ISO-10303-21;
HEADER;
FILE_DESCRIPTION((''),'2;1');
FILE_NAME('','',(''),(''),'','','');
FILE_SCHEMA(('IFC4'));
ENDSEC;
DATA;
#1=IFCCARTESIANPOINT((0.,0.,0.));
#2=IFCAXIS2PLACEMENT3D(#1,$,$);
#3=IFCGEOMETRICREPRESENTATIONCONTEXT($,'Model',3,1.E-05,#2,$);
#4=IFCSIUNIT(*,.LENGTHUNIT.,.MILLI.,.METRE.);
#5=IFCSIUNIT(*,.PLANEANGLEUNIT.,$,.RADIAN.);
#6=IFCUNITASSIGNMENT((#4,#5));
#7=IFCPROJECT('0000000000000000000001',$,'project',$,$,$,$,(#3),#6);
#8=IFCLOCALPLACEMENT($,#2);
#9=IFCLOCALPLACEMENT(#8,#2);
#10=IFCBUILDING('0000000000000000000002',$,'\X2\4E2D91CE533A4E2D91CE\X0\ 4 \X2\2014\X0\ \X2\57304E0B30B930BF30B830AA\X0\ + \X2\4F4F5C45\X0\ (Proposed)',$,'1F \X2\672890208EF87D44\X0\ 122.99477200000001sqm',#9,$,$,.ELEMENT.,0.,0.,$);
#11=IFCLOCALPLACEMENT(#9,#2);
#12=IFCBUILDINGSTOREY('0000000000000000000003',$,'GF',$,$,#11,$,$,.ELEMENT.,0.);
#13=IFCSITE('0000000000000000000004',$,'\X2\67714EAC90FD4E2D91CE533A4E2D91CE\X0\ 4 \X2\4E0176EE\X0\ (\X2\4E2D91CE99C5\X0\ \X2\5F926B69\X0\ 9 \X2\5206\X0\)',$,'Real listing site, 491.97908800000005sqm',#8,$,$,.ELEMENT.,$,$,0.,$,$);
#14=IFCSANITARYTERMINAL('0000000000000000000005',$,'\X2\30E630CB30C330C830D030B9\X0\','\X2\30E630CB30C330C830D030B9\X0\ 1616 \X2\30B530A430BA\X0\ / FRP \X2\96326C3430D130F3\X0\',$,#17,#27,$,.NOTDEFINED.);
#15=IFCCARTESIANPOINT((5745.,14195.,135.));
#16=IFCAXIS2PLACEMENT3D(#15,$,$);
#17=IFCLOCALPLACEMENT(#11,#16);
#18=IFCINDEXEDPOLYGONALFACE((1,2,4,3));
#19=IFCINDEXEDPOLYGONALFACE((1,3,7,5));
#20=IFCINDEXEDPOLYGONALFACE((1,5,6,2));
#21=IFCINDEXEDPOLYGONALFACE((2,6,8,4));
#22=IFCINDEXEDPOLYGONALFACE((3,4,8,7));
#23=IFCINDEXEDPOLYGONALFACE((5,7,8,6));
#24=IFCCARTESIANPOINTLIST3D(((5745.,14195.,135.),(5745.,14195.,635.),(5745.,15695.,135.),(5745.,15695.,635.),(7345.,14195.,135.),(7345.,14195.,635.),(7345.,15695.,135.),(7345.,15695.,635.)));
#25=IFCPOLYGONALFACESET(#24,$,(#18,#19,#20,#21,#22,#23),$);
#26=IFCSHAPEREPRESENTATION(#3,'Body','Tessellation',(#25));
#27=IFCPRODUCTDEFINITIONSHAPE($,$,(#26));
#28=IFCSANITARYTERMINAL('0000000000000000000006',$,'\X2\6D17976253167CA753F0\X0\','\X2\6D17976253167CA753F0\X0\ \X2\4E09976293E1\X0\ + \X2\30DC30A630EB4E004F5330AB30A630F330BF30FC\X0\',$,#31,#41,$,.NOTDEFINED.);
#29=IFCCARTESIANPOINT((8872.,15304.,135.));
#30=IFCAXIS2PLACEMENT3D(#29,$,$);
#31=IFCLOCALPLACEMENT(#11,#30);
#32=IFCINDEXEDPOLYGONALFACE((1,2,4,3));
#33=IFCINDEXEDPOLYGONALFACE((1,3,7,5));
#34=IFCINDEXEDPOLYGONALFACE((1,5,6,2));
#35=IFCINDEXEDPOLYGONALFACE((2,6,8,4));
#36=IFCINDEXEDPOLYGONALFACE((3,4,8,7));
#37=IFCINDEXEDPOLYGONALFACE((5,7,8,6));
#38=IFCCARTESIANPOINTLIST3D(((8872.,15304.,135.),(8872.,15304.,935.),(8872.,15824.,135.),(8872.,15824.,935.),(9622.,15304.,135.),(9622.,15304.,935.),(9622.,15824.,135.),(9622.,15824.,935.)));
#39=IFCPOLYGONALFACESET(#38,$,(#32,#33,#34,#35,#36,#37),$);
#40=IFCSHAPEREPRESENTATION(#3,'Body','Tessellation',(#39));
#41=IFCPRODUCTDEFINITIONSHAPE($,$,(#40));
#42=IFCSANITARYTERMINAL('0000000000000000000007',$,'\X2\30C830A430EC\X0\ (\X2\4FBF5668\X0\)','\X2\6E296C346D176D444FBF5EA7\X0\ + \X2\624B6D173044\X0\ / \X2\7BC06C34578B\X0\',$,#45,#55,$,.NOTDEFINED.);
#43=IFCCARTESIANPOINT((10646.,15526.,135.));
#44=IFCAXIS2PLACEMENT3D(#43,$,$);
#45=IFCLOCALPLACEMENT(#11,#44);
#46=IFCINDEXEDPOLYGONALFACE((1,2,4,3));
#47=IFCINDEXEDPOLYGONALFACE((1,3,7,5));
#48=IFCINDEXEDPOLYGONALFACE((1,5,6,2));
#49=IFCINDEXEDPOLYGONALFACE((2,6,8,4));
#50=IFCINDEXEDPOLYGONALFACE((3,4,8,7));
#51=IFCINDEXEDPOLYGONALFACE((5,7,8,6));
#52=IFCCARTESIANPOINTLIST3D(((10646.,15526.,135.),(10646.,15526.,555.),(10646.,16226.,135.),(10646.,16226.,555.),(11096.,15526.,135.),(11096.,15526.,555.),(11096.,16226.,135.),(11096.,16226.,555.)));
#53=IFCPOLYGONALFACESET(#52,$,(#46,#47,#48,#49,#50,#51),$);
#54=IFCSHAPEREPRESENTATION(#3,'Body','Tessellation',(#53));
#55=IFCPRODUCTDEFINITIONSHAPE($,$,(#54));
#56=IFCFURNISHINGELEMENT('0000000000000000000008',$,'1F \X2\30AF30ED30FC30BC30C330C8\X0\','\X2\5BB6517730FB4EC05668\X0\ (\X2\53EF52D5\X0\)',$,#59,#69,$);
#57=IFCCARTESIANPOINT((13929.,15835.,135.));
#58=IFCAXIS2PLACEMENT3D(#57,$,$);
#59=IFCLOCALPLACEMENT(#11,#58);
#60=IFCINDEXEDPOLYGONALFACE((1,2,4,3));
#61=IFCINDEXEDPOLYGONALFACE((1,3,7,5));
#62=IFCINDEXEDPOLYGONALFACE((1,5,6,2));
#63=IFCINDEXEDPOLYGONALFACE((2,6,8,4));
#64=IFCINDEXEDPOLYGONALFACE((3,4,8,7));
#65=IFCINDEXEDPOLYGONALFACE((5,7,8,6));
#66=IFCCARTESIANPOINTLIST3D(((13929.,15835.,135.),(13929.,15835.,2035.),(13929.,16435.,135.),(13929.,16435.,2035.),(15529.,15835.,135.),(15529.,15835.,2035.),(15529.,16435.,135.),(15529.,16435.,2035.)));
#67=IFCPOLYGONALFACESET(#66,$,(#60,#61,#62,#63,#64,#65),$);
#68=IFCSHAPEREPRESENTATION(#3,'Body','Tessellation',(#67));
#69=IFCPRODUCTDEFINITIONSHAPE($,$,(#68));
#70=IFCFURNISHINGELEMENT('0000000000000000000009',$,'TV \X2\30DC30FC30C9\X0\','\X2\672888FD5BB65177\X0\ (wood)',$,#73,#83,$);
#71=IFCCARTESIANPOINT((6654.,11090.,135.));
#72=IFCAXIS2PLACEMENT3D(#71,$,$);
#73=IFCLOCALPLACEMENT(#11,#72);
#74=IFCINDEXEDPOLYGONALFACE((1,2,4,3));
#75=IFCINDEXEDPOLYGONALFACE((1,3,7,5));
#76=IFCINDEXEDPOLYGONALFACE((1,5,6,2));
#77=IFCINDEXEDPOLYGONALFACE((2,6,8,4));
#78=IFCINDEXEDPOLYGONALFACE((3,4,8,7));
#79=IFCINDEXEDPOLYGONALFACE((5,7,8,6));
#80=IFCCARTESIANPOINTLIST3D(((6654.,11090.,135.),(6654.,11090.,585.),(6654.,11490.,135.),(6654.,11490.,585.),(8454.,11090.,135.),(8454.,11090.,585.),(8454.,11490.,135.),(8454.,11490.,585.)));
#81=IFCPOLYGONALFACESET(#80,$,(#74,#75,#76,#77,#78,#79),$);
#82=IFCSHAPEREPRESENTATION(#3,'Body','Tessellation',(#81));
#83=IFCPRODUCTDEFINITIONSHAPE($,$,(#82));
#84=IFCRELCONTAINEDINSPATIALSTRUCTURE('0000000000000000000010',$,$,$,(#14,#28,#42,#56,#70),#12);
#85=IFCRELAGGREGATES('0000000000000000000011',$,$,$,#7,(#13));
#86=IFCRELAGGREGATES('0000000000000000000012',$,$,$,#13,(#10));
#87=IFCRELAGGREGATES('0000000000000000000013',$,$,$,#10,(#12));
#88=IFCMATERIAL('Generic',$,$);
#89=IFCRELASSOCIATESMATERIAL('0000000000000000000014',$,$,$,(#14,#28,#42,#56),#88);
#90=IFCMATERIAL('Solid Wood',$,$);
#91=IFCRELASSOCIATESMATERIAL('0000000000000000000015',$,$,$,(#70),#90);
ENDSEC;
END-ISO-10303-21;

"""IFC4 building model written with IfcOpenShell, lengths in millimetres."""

from ifc_helpers import new_model, si_unit, frame, frame_2d, origin, place, context, project, spatial, rectangle, extrude, material, element, save


model = new_model("IFC4")

# Units and contexts
model_context = context("Model", 3, precision=1e-05, world=origin())
ifc_project = project(units=[si_unit("LENGTHUNIT", "METRE", prefix="MILLI"), si_unit("PLANEANGLEUNIT", "RADIAN")], contexts=[model_context])

# Site, building, storey
site_placement = place(None, origin())
site = spatial("IfcSite", under=ifc_project, at=site_placement, Name="東京都中野区中野 4 丁目 (中野駅 徒歩 9 分)", ObjectType="Real listing site, 491.97908800000005sqm", CompositionType="ELEMENT", RefElevation=0.0)
building_placement = place(site_placement, origin())
building = spatial("IfcBuilding", under=site, at=building_placement, Name="中野区中野 4 — 地下スタジオ + 住居 (Proposed)", ObjectType="1F 木造軸組 122.99477200000001sqm", CompositionType="ELEMENT", ElevationOfRefHeight=0.0, ElevationOfTerrain=0.0)
storey_placement = place(building_placement, origin())
storey = spatial("IfcBuildingStorey", under=building, at=storey_placement, Name="GF", CompositionType="ELEMENT", Elevation=0.0)

# Shared definitions
ifc_material_1 = material(Name="Solid Wood")

# Sanitary terminals
ifc_material_2 = material(Name="Generic")
sanitary_terminal_1_placement = place(storey_placement, frame((5745.0, 14195.0, 135.0)))
element("IfcSanitaryTerminal", 1, at=sanitary_terminal_1_placement, inside=storey, material=ifc_material_2, Name="ユニットバス", Description="ユニットバス 1616 サイズ / FRP 防水パン", PredefinedType="NOTDEFINED", context=model_context, shape_type="SweptSolid", body=[
    extrude(rectangle(XDim=1600.0, YDim=1500.0, at=frame_2d((800.0, 750.0))), frame((5745.0, 14195.0, 135.0)), (0.0, 0.0, 1.0), 500.0),
])
sanitary_terminal_2_placement = place(storey_placement, frame((8872.0, 15304.0, 135.0)))
element("IfcSanitaryTerminal", 2, at=sanitary_terminal_2_placement, inside=storey, material=ifc_material_2, Name="洗面化粧台", Description="洗面化粧台 三面鏡 + ボウル一体カウンター", PredefinedType="NOTDEFINED", context=model_context, shape_type="SweptSolid", body=[
    extrude(rectangle(XDim=750.0, YDim=520.0, at=frame_2d((375.0, 260.0))), frame((8872.0, 15304.0, 135.0)), (0.0, 0.0, 1.0), 800.0),
])
sanitary_terminal_3_placement = place(storey_placement, frame((10646.0, 15526.0, 135.0)))
element("IfcSanitaryTerminal", 3, at=sanitary_terminal_3_placement, inside=storey, material=ifc_material_2, Name="トイレ (便器)", Description="温水洗浄便座 + 手洗い / 節水型", PredefinedType="NOTDEFINED", context=model_context, shape_type="SweptSolid", body=[
    extrude(rectangle(XDim=450.0, YDim=700.0, at=frame_2d((225.0, 350.0))), frame((10646.0, 15526.0, 135.0)), (0.0, 0.0, 1.0), 420.0),
])

# Furnishing elements
furnishing_1_placement = place(storey_placement, frame((13929.0, 15835.0, 135.0)))
element("IfcFurnishingElement", 4, at=furnishing_1_placement, inside=storey, material=ifc_material_2, Name="1F クローゼット", Description="家具・什器 (可動)", context=model_context, shape_type="SweptSolid", body=[
    extrude(rectangle(XDim=1600.0, YDim=600.0, at=frame_2d((800.0, 300.0))), frame((13929.0, 15835.0, 135.0)), (0.0, 0.0, 1.0), 1900.0),
])
furnishing_2_placement = place(storey_placement, frame((6654.0, 11090.0, 135.0)))
element("IfcFurnishingElement", 5, at=furnishing_2_placement, inside=storey, material=ifc_material_1, Name="TV ボード", Description="木製家具 (wood)", context=model_context, shape_type="SweptSolid", body=[
    extrude(rectangle(XDim=1800.0, YDim=400.0, at=frame_2d((900.0, 200.0))), frame((6654.0, 11090.0, 135.0)), (0.0, 0.0, 1.0), 450.0),
])

save(model, "model.ifc")
